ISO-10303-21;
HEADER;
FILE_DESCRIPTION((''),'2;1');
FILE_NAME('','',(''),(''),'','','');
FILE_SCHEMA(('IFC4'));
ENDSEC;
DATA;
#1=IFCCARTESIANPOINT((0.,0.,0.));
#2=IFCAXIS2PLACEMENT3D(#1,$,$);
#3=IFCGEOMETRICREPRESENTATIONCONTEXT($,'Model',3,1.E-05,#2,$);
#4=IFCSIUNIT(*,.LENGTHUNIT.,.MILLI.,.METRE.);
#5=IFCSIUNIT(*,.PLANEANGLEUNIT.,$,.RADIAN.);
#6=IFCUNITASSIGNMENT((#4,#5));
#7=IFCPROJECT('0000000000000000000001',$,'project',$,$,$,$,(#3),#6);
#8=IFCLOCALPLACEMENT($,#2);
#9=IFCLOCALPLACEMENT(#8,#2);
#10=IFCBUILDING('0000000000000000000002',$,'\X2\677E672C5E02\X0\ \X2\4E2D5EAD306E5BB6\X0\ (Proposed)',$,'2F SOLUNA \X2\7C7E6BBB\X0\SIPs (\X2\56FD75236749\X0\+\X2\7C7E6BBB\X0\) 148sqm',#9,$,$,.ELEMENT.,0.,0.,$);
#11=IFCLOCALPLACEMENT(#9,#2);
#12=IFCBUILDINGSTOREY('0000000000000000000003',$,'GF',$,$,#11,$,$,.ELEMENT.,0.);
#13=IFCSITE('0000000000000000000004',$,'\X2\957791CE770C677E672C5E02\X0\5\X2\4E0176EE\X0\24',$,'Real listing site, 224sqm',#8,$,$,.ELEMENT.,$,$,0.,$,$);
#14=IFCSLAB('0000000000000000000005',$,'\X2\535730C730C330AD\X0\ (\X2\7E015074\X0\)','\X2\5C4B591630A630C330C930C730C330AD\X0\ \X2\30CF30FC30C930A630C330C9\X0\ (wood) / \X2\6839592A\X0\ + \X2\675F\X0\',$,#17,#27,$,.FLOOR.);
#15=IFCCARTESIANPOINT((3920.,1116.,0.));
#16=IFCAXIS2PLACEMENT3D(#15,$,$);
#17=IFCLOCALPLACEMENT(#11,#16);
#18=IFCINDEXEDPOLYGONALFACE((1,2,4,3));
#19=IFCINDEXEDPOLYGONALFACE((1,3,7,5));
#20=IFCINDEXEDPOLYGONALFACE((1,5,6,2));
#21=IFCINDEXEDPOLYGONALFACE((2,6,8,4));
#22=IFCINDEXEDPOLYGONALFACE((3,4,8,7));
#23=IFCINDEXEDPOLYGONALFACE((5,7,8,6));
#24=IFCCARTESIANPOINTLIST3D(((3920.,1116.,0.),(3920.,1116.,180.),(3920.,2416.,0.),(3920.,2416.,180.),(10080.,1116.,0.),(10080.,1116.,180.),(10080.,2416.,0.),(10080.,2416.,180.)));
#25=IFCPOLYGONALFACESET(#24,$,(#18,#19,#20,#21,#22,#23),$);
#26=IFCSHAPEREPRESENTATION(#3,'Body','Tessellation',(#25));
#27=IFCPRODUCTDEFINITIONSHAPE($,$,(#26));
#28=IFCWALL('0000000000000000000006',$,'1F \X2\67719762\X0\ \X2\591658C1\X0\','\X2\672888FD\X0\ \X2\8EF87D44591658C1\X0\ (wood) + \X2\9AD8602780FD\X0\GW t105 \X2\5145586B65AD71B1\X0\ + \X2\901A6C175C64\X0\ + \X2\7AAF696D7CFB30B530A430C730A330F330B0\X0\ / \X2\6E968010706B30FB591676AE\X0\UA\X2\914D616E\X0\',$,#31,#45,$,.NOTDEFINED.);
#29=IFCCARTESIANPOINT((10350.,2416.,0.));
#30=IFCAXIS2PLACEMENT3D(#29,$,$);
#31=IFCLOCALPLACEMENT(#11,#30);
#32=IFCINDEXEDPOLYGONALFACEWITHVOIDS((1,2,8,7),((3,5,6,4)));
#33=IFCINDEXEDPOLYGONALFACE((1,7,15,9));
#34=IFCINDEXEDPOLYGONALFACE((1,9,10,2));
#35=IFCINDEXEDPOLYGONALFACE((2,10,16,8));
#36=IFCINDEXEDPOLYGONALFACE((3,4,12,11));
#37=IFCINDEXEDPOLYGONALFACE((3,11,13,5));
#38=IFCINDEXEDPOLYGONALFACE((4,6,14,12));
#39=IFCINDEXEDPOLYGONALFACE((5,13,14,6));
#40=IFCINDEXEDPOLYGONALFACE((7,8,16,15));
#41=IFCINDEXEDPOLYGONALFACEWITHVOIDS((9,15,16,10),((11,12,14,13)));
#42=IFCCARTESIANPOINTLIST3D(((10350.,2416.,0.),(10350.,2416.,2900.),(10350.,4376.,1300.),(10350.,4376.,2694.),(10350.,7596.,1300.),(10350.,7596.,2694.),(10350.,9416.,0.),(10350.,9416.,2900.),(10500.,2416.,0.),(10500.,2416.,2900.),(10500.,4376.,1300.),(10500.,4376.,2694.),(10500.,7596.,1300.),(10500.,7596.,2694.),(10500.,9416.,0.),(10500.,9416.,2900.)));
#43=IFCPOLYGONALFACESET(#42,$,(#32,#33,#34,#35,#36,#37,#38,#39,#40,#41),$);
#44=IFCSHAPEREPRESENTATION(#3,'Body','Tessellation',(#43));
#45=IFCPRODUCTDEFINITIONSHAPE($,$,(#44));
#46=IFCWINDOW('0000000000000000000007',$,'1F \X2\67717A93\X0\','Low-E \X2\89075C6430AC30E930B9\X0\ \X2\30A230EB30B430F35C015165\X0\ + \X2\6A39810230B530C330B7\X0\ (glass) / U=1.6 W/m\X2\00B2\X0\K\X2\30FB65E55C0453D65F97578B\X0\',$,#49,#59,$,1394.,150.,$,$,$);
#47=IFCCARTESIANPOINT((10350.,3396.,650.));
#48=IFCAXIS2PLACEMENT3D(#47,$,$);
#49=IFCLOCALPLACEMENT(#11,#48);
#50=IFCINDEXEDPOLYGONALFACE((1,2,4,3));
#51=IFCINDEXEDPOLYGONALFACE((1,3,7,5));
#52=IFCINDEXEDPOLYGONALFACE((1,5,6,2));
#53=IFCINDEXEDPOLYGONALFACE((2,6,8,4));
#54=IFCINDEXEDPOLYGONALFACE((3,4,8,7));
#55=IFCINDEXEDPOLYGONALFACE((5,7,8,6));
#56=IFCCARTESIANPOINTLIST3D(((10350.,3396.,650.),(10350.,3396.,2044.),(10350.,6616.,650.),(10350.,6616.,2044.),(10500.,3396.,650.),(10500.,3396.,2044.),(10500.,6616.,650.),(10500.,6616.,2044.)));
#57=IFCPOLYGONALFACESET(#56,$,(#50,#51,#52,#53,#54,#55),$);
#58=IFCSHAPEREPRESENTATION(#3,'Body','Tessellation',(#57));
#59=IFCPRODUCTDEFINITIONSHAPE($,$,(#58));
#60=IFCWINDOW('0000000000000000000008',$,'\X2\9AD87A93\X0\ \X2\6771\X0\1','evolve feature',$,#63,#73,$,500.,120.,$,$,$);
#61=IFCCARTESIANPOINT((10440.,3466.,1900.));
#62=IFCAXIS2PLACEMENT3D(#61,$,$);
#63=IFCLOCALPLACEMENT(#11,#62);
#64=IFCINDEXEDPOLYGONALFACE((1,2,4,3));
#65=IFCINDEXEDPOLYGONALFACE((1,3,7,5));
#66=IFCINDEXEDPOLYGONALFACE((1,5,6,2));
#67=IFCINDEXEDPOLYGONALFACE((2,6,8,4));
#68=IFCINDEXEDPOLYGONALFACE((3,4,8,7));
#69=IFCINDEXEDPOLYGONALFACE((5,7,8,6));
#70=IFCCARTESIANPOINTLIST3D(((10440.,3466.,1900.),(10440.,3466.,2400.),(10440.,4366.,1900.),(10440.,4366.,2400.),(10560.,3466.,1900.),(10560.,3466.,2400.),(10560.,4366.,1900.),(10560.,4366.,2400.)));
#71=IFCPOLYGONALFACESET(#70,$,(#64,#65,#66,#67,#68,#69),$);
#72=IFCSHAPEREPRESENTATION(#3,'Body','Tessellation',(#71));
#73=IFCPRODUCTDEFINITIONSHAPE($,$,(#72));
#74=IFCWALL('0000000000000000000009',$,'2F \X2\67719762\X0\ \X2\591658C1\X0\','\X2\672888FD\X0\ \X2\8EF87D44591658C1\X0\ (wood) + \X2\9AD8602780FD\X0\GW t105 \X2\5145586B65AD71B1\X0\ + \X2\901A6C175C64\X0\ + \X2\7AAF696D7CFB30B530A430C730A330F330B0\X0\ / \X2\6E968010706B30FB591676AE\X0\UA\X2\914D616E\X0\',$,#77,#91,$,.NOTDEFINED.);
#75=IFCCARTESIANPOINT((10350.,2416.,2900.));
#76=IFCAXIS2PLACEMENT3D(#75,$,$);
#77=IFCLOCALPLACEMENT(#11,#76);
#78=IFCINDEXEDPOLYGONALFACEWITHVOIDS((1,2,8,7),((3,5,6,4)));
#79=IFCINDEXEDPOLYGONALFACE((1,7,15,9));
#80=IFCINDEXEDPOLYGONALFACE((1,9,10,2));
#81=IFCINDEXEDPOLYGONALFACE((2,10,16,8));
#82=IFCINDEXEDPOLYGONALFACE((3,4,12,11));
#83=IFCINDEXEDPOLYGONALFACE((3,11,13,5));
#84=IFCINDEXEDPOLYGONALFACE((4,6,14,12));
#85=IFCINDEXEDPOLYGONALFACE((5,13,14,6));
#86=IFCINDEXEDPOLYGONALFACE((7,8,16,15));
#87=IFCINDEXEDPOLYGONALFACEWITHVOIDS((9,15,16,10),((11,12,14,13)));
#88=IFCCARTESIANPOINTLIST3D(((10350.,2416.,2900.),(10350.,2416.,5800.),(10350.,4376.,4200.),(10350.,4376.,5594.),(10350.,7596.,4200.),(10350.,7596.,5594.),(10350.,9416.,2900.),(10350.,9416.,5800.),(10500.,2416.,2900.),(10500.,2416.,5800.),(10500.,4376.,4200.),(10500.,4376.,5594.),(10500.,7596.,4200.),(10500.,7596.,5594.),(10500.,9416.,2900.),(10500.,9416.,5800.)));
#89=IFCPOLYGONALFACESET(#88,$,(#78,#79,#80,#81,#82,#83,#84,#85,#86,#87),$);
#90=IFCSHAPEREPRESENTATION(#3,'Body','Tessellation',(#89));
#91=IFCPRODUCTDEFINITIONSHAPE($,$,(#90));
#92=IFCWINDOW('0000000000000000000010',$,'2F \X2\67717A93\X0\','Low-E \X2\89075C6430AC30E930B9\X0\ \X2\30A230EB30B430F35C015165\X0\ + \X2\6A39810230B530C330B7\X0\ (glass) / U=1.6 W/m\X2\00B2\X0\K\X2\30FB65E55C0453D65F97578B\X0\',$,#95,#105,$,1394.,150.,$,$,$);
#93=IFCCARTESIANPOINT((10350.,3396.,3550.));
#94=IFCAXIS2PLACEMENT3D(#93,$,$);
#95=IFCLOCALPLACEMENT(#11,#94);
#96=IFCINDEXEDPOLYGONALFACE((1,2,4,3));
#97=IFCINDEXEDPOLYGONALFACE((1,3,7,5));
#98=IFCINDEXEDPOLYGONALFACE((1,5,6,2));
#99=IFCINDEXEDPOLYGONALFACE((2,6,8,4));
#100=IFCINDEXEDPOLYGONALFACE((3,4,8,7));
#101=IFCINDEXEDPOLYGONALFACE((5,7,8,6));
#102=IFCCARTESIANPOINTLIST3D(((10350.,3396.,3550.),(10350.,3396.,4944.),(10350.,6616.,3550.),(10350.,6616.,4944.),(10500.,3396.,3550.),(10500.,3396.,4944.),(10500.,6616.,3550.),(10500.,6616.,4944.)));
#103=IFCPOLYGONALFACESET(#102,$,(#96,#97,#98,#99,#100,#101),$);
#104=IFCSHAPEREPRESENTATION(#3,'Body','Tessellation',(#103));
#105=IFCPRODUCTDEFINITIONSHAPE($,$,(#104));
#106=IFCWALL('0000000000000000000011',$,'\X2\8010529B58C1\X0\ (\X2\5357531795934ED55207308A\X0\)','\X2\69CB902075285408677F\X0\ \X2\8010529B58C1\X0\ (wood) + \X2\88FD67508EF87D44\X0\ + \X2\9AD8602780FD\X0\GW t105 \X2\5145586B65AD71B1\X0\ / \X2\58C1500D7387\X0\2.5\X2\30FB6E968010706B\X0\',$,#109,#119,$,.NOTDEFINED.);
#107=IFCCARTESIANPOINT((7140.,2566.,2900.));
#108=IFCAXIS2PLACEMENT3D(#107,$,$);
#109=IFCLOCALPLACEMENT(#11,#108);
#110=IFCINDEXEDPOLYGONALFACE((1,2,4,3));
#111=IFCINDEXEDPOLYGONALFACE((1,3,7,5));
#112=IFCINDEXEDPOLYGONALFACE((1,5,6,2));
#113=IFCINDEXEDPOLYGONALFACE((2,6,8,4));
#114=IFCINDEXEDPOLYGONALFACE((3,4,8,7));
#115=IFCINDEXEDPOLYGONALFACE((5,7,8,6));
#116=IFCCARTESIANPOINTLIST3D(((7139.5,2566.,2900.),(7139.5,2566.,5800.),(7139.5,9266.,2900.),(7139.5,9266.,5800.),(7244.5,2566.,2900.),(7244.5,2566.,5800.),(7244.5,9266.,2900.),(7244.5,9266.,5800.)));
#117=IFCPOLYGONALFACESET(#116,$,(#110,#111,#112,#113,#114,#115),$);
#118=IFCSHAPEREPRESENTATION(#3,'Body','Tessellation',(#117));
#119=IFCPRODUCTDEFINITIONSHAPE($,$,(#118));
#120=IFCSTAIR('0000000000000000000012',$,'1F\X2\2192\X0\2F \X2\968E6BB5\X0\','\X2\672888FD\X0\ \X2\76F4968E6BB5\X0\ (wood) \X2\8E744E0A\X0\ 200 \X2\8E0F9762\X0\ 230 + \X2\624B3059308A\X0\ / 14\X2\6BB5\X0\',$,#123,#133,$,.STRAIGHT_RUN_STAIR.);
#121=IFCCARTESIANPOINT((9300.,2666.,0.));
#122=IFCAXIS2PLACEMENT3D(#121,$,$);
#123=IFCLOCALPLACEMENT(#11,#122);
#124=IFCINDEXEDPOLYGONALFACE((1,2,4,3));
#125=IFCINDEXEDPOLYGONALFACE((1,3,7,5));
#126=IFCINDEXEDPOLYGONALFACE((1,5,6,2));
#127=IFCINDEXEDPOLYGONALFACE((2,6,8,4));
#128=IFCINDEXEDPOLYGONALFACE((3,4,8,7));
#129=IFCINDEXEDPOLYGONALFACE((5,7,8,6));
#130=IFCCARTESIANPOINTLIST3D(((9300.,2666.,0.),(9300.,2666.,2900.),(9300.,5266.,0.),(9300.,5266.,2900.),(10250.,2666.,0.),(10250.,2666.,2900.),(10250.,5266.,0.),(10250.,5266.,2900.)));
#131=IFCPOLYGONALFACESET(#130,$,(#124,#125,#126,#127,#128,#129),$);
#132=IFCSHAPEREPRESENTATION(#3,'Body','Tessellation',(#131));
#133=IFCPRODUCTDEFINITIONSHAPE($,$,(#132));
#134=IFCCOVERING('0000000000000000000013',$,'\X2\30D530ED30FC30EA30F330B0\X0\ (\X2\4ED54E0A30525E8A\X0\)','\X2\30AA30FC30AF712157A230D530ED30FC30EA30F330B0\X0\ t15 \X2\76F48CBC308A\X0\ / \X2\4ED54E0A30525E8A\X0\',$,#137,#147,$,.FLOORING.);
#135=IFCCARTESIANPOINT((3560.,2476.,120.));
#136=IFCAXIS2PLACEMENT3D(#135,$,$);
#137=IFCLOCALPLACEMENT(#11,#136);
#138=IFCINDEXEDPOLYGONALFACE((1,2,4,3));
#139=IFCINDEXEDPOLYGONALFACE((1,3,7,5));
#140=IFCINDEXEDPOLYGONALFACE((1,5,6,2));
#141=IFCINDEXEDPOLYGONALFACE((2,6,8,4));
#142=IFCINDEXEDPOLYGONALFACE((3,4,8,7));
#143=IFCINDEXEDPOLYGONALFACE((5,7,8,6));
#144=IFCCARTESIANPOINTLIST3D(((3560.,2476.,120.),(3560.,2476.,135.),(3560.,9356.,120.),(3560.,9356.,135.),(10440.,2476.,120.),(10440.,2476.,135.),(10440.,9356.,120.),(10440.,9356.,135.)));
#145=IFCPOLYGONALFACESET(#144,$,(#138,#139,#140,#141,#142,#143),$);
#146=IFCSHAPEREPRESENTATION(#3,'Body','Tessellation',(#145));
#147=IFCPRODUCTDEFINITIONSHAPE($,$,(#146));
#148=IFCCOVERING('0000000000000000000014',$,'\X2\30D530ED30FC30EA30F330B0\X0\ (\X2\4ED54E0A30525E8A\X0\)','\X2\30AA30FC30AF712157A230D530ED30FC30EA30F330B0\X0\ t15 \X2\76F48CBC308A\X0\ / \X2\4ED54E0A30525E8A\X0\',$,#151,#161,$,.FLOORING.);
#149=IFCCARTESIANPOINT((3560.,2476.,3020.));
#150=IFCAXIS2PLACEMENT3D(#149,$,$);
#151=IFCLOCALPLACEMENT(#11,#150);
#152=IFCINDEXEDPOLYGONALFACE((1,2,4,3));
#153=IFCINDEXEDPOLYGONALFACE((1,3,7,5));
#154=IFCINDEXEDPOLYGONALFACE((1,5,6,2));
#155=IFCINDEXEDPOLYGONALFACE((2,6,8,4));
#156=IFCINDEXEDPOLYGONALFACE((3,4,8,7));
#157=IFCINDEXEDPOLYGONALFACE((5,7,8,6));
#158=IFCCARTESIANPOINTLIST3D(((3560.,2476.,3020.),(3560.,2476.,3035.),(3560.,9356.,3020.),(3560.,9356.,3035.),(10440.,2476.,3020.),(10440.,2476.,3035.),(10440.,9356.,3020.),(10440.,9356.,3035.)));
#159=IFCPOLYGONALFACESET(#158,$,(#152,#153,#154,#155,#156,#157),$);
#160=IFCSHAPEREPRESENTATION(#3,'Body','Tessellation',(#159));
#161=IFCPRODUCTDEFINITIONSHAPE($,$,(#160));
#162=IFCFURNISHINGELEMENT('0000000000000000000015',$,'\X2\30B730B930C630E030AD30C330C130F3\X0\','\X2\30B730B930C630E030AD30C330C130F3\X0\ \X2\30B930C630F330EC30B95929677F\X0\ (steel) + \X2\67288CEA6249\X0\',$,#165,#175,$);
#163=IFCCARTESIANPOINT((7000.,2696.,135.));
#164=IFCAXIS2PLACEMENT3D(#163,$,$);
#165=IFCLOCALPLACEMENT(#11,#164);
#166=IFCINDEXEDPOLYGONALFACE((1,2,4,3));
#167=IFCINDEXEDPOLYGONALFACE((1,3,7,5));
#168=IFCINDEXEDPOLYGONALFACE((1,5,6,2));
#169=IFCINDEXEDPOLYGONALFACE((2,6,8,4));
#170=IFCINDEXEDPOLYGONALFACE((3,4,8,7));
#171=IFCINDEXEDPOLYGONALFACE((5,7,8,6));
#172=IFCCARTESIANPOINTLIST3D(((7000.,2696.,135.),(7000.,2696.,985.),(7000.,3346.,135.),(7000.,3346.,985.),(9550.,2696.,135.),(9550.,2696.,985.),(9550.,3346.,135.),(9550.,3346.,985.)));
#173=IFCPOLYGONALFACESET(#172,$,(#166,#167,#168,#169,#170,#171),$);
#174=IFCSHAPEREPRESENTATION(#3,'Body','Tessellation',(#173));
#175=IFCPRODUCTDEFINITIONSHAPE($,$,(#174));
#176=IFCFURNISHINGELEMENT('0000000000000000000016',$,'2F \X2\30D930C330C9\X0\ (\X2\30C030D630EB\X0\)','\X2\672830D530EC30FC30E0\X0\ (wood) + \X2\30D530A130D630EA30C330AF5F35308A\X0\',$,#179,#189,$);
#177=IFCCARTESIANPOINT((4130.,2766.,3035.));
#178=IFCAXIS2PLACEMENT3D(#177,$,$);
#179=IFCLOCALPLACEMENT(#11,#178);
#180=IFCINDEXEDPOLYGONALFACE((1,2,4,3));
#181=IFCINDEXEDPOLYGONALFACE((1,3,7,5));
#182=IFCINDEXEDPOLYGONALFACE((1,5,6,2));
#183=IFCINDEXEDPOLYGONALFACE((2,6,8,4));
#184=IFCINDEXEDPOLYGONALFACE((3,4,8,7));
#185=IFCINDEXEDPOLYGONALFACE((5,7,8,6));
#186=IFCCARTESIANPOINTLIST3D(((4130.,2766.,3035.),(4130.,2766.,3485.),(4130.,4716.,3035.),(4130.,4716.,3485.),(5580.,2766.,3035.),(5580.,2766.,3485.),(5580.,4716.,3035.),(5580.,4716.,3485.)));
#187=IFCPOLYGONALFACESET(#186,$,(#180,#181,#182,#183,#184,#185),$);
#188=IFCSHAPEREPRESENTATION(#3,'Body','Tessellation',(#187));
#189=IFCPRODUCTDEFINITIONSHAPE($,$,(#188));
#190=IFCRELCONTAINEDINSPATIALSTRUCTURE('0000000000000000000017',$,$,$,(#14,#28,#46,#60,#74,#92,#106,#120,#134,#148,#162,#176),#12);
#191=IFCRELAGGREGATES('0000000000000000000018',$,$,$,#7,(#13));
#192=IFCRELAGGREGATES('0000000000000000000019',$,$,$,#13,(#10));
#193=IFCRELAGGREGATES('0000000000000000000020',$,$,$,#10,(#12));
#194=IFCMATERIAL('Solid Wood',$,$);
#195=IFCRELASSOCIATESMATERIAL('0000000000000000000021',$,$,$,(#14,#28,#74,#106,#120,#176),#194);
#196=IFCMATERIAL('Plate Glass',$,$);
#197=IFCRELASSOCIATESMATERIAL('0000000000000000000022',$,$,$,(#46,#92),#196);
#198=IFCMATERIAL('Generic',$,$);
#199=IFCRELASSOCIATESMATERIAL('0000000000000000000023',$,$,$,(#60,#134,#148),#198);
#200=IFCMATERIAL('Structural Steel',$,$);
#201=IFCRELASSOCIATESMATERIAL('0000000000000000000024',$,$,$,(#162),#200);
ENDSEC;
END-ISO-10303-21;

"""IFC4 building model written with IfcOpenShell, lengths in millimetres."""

from ifc_helpers import new_model, si_unit, frame, frame_2d, origin, place, context, project, spatial, rectangle, extrude, material, element, fill, save


model = new_model("IFC4")

# Units and contexts
model_context = context("Model", 3, precision=1e-05, world=origin())
ifc_project = project(units=[si_unit("LENGTHUNIT", "METRE", prefix="MILLI"), si_unit("PLANEANGLEUNIT", "RADIAN")], contexts=[model_context])

# Site, building, storey
site_placement = place(None, origin())
site = spatial("IfcSite", under=ifc_project, at=site_placement, Name="長野県松本市5丁目24", ObjectType="Real listing site, 224sqm", CompositionType="ELEMENT", RefElevation=0.0)
building_placement = place(site_placement, origin())
building = spatial("IfcBuilding", under=site, at=building_placement, Name="松本市 中庭の家 (Proposed)", ObjectType="2F SOLUNA 籾殻SIPs (国産杉+籾殻) 148sqm", CompositionType="ELEMENT", ElevationOfRefHeight=0.0, ElevationOfTerrain=0.0)
storey_placement = place(building_placement, origin())
storey = spatial("IfcBuildingStorey", under=building, at=storey_placement, Name="GF", CompositionType="ELEMENT", Elevation=0.0)

# Slab
ifc_material_1 = material(Name="Solid Wood")
slab_placement = place(storey_placement, frame((3920.0, 1116.0, 0.0)))
element("IfcSlab", 1, at=slab_placement, inside=storey, material=ifc_material_1, Name="南デッキ (縁側)", Description="屋外ウッドデッキ ハードウッド (wood) / 根太 + 束", PredefinedType="FLOOR", context=model_context, shape_type="SweptSolid", body=[
    extrude(rectangle(XDim=6160.0, YDim=1300.0, at=frame_2d((3080.0, 650.0))), frame((3920.0, 1116.0, 0.0)), (0.0, 0.0, 1.0), 180.0),
])

# Wall, openings, windows
wall_1_placement = place(storey_placement, frame((10350.0, 2416.0, 0.0)))
wall_1 = element("IfcWall", 2, at=wall_1_placement, inside=storey, material=ifc_material_1, Name="1F 東面 外壁", Description="木製 軸組外壁 (wood) + 高性能GW t105 充填断熱 + 通気層 + 窯業系サイディング / 準耐火・外皮UA配慮", PredefinedType="NOTDEFINED", context=model_context, shape_type="SweptSolid", body=[
    extrude(rectangle(XDim=150.0, YDim=7000.0, at=frame_2d((75.0, 3500.0))), frame((10350.0, 2416.0, 0.0)), (0.0, 0.0, 1.0), 2900.0),
])
opening_1_placement = place(storey_placement, frame((10350.0, 3396.0, 650.0)))
opening_1 = element("IfcOpeningElement", 3, at=opening_1_placement, cuts=wall_1, PredefinedType="NOTDEFINED", context=model_context, shape_type="SweptSolid", body=[
    extrude(rectangle(XDim=150.0, YDim=3220.0, at=frame_2d((75.0, 1610.0))), frame((10350.0, 3396.0, 650.0)), (0.0, 0.0, 1.0), 1394.0),
])
opening_2_placement = place(storey_placement, frame((10440.0, 3466.0, 1900.0)))
opening_2 = element("IfcOpeningElement", 4, at=opening_2_placement, cuts=wall_1, PredefinedType="NOTDEFINED", context=model_context, shape_type="SweptSolid", body=[
    extrude(rectangle(XDim=120.0, YDim=900.0, at=frame_2d((60.0, 450.0))), frame((10440.0, 3466.0, 1900.0)), (0.0, 0.0, 1.0), 500.0),
])
ifc_material_2 = material(Name="Plate Glass")
window_1_placement = place(storey_placement, frame((10350.0, 3396.0, 650.0)))
window_1 = element("IfcWindow", 5, at=window_1_placement, inside=storey, material=ifc_material_2, Name="1F 東窓", Description="Low-E 複層ガラス アルゴン封入 + 樹脂サッシ (glass) / U=1.6 W/m²K・日射取得型", OverallHeight=1394.0, OverallWidth=150.0, context=model_context, shape_type="SweptSolid", body=[
    extrude(rectangle(XDim=150.0, YDim=3220.0, at=frame_2d((75.0, 1610.0))), frame((10350.0, 3396.0, 650.0)), (0.0, 0.0, 1.0), 1394.0),
])
fill(opening_1, window_1)
ifc_material_3 = material(Name="Generic")
window_2_placement = place(storey_placement, frame((10440.0, 3466.0, 1900.0)))
window_2 = element("IfcWindow", 6, at=window_2_placement, inside=storey, material=ifc_material_3, Name="高窓 東1", Description="evolve feature", OverallHeight=500.0, OverallWidth=120.0, context=model_context, shape_type="SweptSolid", body=[
    extrude(rectangle(XDim=120.0, YDim=900.0, at=frame_2d((60.0, 450.0))), frame((10440.0, 3466.0, 1900.0)), (0.0, 0.0, 1.0), 500.0),
])
fill(opening_2, window_2)

# Wall, opening, window
wall_2_placement = place(storey_placement, frame((10350.0, 2416.0, 2900.0)))
wall_2 = element("IfcWall", 7, at=wall_2_placement, inside=storey, material=ifc_material_1, Name="2F 東面 外壁", Description="木製 軸組外壁 (wood) + 高性能GW t105 充填断熱 + 通気層 + 窯業系サイディング / 準耐火・外皮UA配慮", PredefinedType="NOTDEFINED", context=model_context, shape_type="SweptSolid", body=[
    extrude(rectangle(XDim=150.0, YDim=7000.0, at=frame_2d((75.0, 3500.0))), frame((10350.0, 2416.0, 2900.0)), (0.0, 0.0, 1.0), 2900.0),
])
opening_3_placement = place(storey_placement, frame((10350.0, 3396.0, 3550.0)))
opening_3 = element("IfcOpeningElement", 8, at=opening_3_placement, cuts=wall_2, PredefinedType="NOTDEFINED", context=model_context, shape_type="SweptSolid", body=[
    extrude(rectangle(XDim=150.0, YDim=3220.0, at=frame_2d((75.0, 1610.0))), frame((10350.0, 3396.0, 3550.0)), (0.0, 0.0, 1.0), 1394.0),
])
window_3_placement = place(storey_placement, frame((10350.0, 3396.0, 3550.0)))
window_3 = element("IfcWindow", 9, at=window_3_placement, inside=storey, material=ifc_material_2, Name="2F 東窓", Description="Low-E 複層ガラス アルゴン封入 + 樹脂サッシ (glass) / U=1.6 W/m²K・日射取得型", OverallHeight=1394.0, OverallWidth=150.0, context=model_context, shape_type="SweptSolid", body=[
    extrude(rectangle(XDim=150.0, YDim=3220.0, at=frame_2d((75.0, 1610.0))), frame((10350.0, 3396.0, 3550.0)), (0.0, 0.0, 1.0), 1394.0),
])
fill(opening_3, window_3)

# Wall
wall_3_placement = place(storey_placement, frame((7140.0, 2566.0, 2900.0)))
element("IfcWall", 10, at=wall_3_placement, inside=storey, material=ifc_material_1, Name="耐力壁 (南北間仕切り)", Description="構造用合板 耐力壁 (wood) + 製材軸組 + 高性能GW t105 充填断熱 / 壁倍率2.5・準耐火", PredefinedType="NOTDEFINED", context=model_context, shape_type="SweptSolid", body=[
    extrude(rectangle(XDim=105.0, YDim=6700.0, at=frame_2d((52.0, 3350.0))), frame((7140.0, 2566.0, 2900.0)), (0.0, 0.0, 1.0), 2900.0),
])

# Stair
stair_placement = place(storey_placement, frame((9300.0, 2666.0, 0.0)))
element("IfcStair", 11, at=stair_placement, inside=storey, material=ifc_material_1, Name="1F→2F 階段", Description="木製 直階段 (wood) 蹴上 200 踏面 230 + 手すり / 14段", PredefinedType="STRAIGHT_RUN_STAIR", context=model_context, shape_type="SweptSolid", body=[
    extrude(rectangle(XDim=950.0, YDim=2600.0, at=frame_2d((475.0, 1300.0))), frame((9300.0, 2666.0, 0.0)), (0.0, 0.0, 1.0), 2900.0),
])

# Coverings
covering_1_placement = place(storey_placement, frame((3560.0, 2476.0, 120.0)))
element("IfcCovering", 12, at=covering_1_placement, inside=storey, material=ifc_material_3, Name="フローリング (仕上げ床)", Description="オーク無垢フローリング t15 直貼り / 仕上げ床", PredefinedType="FLOORING", context=model_context, shape_type="SweptSolid", body=[
    extrude(rectangle(XDim=6880.0, YDim=6880.0, at=frame_2d((3440.0, 3440.0))), frame((3560.0, 2476.0, 120.0)), (0.0, 0.0, 1.0), 15.0),
])
covering_2_placement = place(storey_placement, frame((3560.0, 2476.0, 3020.0)))
element("IfcCovering", 13, at=covering_2_placement, inside=storey, material=ifc_material_3, Name="フローリング (仕上げ床)", Description="オーク無垢フローリング t15 直貼り / 仕上げ床", PredefinedType="FLOORING", context=model_context, shape_type="SweptSolid", body=[
    extrude(rectangle(XDim=6880.0, YDim=6880.0, at=frame_2d((3440.0, 3440.0))), frame((3560.0, 2476.0, 3020.0)), (0.0, 0.0, 1.0), 15.0),
])

# Furnishing elements
ifc_material_4 = material(Name="Structural Steel")
furnishing_1_placement = place(storey_placement, frame((7000.0, 2696.0, 135.0)))
element("IfcFurnishingElement", 14, at=furnishing_1_placement, inside=storey, material=ifc_material_4, Name="システムキッチン", Description="システムキッチン ステンレス天板 (steel) + 木質扉", context=model_context, shape_type="SweptSolid", body=[
    extrude(rectangle(XDim=2550.0, YDim=650.0, at=frame_2d((1275.0, 325.0))), frame((7000.0, 2696.0, 135.0)), (0.0, 0.0, 1.0), 850.0),
])
furnishing_2_placement = place(storey_placement, frame((4130.0, 2766.0, 3035.0)))
element("IfcFurnishingElement", 15, at=furnishing_2_placement, inside=storey, material=ifc_material_1, Name="2F ベッド (ダブル)", Description="木フレーム (wood) + ファブリック張り", context=model_context, shape_type="SweptSolid", body=[
    extrude(rectangle(XDim=1450.0, YDim=1950.0, at=frame_2d((725.0, 975.0))), frame((4130.0, 2766.0, 3035.0)), (0.0, 0.0, 1.0), 450.0),
])

save(model, "model.ifc")
